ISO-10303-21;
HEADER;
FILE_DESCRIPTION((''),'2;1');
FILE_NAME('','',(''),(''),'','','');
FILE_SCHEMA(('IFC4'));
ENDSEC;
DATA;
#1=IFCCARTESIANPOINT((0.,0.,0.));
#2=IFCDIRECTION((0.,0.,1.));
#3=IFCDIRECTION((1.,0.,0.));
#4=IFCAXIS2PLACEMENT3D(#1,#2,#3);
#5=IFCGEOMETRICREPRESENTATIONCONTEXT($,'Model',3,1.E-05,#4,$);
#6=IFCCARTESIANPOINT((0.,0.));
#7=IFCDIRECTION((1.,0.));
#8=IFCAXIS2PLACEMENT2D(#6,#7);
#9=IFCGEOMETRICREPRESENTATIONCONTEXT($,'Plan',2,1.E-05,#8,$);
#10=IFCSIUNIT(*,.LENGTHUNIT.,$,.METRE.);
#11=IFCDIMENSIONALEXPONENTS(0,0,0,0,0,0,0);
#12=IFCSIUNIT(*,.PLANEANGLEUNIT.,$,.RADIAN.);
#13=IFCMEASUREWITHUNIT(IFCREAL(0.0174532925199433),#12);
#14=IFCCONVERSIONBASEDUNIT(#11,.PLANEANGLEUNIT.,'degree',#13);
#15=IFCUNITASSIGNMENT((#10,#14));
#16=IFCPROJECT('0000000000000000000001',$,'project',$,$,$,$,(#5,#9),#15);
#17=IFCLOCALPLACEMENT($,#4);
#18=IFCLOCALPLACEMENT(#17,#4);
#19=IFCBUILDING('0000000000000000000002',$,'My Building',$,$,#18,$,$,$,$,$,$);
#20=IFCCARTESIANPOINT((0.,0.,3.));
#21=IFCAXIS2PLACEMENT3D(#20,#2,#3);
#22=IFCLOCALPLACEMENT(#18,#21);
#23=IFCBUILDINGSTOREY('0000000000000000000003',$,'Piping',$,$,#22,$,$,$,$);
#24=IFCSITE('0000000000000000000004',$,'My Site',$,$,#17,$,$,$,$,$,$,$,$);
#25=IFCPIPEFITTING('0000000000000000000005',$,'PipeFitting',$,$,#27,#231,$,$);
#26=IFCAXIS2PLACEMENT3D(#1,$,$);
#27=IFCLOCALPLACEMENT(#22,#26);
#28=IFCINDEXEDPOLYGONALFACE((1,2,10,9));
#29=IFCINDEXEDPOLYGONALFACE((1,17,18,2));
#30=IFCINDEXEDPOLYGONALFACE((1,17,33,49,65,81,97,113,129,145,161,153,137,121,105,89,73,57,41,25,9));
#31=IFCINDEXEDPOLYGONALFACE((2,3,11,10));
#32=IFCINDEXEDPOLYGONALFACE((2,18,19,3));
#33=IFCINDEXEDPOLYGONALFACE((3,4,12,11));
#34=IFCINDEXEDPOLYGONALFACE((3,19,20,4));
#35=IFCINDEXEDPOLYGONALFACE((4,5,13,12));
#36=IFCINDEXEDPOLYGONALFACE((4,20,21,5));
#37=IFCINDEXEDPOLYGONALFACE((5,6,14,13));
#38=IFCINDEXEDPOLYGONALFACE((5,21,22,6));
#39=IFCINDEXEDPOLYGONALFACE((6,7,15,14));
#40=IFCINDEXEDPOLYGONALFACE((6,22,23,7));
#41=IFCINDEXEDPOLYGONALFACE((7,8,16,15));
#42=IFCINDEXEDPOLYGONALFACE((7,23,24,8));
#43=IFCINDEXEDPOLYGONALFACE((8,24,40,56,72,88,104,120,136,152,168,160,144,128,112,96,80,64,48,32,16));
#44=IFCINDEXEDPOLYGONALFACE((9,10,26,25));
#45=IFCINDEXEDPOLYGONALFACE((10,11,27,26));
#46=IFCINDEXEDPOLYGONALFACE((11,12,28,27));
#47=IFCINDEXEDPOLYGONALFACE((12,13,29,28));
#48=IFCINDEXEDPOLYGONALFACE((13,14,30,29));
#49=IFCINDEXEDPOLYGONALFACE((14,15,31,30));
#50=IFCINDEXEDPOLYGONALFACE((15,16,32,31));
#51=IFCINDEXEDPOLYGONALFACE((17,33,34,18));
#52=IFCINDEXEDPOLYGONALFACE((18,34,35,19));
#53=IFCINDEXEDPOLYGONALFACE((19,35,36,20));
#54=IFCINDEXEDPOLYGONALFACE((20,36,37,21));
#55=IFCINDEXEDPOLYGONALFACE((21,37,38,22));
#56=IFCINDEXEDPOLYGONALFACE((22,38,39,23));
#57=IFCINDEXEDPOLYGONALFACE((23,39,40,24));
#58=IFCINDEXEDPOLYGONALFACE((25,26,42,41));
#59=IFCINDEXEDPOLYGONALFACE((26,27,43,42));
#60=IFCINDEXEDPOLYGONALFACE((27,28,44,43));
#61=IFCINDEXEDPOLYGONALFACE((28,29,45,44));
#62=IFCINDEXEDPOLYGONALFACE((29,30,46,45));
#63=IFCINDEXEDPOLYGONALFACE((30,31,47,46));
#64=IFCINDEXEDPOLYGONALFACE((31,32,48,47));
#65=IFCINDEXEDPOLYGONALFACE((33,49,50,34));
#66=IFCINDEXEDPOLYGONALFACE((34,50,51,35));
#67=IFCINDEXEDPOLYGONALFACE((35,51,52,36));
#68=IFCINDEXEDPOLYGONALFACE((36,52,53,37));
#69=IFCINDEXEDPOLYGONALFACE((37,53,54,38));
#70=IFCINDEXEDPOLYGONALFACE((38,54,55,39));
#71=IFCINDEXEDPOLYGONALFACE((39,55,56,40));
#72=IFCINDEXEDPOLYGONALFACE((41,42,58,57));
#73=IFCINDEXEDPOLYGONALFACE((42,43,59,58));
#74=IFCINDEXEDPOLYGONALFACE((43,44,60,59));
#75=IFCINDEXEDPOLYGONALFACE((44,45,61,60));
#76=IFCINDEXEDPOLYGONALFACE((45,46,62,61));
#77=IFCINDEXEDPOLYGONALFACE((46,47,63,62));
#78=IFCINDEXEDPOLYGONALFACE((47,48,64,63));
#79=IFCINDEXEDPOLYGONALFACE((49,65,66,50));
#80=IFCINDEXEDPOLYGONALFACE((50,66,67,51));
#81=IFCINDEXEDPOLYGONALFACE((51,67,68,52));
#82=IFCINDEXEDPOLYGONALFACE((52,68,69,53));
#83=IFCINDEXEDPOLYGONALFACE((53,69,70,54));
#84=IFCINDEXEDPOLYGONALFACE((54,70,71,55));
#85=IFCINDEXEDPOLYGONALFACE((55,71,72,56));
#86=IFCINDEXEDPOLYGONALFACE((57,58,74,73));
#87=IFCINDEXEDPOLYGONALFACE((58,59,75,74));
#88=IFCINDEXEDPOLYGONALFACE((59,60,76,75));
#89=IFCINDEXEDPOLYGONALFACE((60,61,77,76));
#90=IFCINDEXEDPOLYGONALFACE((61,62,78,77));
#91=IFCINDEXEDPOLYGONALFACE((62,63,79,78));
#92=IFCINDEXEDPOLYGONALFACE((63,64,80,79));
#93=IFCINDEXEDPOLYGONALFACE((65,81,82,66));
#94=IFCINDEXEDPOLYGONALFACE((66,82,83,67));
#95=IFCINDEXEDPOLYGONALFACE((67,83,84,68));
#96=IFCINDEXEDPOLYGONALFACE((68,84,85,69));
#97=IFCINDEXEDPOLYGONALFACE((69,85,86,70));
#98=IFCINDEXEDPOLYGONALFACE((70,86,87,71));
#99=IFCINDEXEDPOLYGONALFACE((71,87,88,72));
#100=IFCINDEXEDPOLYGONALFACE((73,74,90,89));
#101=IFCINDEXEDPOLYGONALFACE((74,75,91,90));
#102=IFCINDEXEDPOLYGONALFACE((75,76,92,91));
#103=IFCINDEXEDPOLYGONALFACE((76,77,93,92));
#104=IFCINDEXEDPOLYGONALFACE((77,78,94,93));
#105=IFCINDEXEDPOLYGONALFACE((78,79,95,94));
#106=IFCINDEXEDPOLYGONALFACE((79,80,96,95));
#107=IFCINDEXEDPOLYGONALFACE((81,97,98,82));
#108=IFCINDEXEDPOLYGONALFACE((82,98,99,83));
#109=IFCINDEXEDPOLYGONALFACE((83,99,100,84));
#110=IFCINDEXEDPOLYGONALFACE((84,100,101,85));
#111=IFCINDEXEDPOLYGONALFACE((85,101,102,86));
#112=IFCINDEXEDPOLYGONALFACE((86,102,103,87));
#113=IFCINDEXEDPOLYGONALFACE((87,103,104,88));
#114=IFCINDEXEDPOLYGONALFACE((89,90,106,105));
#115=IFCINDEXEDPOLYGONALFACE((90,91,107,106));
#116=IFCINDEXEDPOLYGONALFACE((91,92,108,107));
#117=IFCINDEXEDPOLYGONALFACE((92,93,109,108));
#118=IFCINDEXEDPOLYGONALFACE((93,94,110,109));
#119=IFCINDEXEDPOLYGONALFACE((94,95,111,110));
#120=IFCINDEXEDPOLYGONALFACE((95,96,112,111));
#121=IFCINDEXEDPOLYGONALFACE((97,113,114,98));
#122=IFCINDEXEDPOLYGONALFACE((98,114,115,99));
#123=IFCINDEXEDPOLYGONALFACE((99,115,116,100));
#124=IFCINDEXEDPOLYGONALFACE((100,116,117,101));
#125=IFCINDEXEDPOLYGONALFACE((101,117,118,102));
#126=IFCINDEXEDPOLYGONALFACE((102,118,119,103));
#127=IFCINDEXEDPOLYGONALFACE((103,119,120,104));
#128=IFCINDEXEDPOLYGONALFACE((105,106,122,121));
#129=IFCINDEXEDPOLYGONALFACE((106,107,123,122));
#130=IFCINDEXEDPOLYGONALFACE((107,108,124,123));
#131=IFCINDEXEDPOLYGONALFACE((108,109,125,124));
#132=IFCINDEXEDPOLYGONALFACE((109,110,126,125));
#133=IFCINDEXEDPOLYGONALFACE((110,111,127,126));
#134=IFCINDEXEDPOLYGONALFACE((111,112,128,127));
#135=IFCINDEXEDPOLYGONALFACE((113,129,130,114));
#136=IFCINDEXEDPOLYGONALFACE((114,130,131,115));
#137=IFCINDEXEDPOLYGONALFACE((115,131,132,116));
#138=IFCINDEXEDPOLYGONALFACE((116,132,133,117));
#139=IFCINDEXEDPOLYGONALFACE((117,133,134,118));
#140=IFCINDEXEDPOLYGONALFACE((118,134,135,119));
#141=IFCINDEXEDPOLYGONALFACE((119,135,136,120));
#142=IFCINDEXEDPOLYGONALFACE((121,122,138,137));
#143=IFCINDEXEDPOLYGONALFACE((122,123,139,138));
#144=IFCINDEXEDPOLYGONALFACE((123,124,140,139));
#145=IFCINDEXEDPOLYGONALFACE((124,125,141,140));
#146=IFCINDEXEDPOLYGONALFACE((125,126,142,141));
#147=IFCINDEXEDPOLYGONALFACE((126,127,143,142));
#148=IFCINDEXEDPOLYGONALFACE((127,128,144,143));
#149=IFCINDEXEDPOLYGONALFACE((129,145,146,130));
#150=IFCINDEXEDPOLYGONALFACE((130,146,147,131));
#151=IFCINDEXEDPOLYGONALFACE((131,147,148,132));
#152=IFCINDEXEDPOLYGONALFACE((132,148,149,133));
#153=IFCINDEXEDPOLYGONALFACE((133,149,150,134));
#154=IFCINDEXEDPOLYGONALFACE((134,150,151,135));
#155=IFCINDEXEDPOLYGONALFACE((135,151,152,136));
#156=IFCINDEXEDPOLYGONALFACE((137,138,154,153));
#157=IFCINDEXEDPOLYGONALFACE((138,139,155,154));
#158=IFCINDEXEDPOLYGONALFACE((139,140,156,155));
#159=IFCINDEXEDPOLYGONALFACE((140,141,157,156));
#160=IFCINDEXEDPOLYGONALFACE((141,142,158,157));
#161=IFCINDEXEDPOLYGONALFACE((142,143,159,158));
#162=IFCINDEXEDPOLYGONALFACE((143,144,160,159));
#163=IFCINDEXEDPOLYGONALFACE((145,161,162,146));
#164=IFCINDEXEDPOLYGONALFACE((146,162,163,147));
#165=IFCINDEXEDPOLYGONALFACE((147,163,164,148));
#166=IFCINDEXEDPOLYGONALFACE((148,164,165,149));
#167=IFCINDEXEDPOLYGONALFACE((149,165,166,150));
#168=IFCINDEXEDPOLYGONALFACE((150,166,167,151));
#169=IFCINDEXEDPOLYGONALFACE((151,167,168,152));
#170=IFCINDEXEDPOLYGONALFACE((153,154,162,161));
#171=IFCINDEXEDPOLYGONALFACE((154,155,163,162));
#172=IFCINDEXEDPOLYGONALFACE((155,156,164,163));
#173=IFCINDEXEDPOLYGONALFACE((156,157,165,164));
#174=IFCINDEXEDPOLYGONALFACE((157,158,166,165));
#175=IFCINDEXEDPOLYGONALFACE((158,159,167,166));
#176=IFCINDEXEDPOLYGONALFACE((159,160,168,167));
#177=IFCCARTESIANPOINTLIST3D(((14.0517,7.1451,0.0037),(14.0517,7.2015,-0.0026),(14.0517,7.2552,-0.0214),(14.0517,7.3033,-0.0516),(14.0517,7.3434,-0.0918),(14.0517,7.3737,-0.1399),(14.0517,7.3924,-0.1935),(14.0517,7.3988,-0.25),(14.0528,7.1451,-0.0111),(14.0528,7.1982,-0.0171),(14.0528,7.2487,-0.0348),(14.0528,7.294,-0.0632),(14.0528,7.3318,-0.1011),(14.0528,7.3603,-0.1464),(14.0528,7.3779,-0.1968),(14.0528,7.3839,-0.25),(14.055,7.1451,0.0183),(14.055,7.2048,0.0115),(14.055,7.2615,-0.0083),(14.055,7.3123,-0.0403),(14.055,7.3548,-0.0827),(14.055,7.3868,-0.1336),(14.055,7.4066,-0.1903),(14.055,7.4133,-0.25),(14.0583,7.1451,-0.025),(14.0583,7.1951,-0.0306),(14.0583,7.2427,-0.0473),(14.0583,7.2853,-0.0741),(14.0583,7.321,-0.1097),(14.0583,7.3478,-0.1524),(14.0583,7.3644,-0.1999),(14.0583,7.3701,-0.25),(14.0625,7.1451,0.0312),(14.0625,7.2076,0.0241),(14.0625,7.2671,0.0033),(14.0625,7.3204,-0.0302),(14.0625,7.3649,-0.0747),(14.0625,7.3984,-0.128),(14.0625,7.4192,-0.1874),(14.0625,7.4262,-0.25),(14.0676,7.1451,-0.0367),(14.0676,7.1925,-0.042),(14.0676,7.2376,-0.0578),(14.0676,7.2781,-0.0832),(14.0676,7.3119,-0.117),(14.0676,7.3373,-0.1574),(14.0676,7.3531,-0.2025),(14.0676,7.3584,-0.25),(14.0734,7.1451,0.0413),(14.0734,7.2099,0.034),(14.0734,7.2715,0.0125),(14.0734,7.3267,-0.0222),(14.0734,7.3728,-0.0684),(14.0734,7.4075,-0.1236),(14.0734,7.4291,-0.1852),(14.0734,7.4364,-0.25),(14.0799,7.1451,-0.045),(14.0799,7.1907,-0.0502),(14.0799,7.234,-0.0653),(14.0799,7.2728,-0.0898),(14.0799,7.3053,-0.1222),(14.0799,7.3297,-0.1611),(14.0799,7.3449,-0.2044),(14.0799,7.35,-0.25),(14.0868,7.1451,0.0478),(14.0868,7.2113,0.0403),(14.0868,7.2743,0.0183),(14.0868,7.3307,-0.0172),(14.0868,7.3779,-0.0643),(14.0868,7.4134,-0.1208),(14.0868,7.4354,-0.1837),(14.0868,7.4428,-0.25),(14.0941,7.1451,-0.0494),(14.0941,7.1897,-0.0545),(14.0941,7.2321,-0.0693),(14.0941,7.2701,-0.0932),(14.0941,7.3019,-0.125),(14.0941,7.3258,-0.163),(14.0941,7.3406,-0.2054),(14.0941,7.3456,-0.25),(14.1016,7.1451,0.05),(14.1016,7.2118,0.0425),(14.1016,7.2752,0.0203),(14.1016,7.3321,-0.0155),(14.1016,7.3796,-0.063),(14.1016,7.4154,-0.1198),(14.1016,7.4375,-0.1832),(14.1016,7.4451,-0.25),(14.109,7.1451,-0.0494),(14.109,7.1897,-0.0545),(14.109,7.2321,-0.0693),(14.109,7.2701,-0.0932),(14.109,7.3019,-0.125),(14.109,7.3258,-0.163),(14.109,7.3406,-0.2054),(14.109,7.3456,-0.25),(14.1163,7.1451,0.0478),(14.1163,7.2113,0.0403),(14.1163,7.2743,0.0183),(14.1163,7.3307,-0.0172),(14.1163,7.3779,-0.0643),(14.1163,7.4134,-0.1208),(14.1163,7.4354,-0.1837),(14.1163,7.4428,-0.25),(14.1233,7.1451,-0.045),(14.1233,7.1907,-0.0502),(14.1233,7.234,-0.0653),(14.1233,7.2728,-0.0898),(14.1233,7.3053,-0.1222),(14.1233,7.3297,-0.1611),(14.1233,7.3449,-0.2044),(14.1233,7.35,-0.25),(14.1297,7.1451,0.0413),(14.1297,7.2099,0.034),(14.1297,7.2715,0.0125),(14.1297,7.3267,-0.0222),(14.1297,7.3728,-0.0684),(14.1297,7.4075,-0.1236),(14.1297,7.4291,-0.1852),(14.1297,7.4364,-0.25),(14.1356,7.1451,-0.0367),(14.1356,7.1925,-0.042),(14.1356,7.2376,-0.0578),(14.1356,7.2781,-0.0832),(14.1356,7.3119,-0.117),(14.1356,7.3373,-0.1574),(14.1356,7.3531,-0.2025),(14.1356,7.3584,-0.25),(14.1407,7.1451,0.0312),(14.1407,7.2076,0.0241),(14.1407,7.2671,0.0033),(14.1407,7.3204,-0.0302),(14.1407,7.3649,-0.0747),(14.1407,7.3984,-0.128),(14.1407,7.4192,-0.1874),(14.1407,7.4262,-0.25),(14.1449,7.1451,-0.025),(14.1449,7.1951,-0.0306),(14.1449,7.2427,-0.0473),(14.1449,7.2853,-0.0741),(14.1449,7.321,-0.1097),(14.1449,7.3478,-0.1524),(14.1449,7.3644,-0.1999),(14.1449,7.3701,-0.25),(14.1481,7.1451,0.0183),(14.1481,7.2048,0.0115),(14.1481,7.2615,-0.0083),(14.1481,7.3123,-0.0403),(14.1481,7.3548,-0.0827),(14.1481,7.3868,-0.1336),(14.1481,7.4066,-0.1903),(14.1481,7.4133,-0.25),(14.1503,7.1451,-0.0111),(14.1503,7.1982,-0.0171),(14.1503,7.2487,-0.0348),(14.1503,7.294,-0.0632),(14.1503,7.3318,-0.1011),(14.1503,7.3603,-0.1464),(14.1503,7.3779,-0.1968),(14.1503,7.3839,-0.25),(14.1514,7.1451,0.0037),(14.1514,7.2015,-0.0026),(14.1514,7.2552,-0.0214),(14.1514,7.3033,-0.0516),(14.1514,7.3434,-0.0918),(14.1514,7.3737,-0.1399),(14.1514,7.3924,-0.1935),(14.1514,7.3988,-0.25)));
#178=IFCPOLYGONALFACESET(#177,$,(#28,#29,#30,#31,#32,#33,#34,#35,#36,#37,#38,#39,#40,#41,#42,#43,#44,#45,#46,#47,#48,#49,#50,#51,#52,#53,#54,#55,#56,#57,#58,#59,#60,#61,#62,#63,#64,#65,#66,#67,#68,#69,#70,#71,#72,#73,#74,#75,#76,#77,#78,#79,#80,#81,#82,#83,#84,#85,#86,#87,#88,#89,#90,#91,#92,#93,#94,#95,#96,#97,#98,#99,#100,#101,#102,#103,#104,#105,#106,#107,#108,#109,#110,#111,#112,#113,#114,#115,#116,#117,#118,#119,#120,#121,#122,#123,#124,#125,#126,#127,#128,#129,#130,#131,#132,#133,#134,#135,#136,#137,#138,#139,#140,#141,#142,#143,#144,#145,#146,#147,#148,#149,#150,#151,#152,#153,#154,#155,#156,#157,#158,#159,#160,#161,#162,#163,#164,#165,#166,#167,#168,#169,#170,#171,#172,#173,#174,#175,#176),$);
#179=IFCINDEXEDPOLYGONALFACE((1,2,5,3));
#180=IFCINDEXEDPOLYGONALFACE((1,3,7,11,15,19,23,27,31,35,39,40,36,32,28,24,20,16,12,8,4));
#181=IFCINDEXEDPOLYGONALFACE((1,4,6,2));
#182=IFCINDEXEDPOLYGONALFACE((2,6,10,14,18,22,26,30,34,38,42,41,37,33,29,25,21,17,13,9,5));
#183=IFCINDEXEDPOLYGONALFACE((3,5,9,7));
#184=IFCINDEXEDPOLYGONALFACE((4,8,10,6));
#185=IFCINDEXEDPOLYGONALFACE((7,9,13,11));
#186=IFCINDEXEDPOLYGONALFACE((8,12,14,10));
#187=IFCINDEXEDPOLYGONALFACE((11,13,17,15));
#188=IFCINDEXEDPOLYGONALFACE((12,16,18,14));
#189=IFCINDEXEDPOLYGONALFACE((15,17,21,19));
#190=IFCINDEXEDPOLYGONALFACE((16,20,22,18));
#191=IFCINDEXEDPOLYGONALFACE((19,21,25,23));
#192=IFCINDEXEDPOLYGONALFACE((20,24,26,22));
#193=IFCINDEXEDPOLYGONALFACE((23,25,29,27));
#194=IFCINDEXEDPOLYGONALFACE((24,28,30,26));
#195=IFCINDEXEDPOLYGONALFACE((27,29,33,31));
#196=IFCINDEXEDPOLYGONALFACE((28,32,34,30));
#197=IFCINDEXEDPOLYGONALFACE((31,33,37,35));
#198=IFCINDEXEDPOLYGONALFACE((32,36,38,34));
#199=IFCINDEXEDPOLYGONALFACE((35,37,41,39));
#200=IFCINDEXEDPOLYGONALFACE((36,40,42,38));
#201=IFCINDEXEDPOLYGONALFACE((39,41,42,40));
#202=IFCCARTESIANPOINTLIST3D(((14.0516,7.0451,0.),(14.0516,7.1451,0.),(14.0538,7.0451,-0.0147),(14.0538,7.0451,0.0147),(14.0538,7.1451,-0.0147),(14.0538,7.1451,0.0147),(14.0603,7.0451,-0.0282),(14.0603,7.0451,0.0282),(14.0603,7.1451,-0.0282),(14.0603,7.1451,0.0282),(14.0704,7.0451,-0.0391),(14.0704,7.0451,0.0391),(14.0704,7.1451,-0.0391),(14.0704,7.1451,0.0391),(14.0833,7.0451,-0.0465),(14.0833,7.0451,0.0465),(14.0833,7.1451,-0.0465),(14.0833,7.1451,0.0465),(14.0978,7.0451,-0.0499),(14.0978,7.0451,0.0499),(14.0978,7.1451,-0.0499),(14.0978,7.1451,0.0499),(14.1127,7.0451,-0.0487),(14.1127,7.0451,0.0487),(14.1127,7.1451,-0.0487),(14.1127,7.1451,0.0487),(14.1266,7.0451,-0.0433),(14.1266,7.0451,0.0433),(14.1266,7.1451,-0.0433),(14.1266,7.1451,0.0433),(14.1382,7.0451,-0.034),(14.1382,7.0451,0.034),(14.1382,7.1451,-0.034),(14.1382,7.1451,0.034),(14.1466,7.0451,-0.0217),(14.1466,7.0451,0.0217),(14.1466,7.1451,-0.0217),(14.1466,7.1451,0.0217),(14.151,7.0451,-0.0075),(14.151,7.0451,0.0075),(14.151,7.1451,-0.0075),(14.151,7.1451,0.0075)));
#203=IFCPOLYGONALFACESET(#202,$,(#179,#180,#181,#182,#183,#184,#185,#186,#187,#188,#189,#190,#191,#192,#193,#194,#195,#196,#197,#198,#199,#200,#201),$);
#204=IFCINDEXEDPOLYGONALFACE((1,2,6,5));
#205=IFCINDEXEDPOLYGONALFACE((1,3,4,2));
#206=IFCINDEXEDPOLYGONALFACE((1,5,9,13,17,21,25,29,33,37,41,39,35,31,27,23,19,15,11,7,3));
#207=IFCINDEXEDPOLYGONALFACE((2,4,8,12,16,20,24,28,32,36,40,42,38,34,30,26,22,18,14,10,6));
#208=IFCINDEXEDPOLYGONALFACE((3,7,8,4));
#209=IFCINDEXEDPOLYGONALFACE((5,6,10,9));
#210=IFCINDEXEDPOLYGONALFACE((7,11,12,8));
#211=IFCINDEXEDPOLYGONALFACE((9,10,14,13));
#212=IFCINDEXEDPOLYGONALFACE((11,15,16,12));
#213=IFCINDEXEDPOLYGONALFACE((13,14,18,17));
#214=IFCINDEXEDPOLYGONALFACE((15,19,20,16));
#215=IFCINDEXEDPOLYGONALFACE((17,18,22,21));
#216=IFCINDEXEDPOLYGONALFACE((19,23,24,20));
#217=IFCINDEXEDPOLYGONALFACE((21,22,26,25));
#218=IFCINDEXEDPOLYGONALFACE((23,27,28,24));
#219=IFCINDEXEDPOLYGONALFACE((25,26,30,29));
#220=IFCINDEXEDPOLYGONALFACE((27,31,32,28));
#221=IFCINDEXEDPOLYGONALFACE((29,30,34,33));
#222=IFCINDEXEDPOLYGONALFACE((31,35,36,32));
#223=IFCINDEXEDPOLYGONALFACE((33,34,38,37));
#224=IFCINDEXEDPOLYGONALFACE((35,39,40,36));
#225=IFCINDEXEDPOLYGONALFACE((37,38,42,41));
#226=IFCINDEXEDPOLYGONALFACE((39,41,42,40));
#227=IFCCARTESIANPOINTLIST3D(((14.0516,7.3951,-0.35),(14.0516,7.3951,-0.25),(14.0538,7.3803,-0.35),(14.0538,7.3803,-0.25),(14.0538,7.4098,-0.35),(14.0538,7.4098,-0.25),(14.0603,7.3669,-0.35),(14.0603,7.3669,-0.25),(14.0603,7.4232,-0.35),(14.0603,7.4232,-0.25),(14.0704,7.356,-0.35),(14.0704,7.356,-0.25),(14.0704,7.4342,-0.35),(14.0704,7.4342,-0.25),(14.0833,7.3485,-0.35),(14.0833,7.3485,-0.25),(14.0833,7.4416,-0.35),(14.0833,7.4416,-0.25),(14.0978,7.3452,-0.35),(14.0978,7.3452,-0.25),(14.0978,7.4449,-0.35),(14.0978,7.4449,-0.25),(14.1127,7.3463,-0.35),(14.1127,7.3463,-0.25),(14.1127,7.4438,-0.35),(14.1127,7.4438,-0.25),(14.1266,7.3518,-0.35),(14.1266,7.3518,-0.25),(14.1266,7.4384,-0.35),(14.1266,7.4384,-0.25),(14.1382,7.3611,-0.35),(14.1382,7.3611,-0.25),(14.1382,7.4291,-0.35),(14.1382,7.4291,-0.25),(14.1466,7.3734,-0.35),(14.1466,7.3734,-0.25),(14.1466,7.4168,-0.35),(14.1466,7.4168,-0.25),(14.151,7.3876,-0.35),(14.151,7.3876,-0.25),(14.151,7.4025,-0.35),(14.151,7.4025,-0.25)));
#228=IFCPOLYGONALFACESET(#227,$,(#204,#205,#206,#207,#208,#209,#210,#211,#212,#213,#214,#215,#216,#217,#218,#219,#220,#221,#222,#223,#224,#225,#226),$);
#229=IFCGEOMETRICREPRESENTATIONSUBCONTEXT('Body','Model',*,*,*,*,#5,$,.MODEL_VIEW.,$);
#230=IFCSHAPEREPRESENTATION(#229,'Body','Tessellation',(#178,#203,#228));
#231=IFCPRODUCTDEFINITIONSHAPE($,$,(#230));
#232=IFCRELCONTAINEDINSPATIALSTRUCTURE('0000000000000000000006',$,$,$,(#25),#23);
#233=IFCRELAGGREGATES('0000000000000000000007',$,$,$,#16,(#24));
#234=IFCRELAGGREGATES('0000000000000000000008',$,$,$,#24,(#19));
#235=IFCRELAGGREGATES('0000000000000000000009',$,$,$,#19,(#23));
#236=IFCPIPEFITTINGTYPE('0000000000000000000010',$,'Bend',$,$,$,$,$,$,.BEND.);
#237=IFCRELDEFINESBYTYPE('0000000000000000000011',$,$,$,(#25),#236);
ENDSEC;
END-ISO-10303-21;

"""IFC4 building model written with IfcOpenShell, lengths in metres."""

from ifc_helpers import new_model, entity, si_unit, converted_unit, frame, origin_with_axes, origin_2d_with_axis, place, context, subcontext, project, spatial, circle, extrude, source, transform, mapped, type_object, type_shapes, element, save


model = new_model("IFC4")

# Units and contexts
model_context = context("Model", 3, precision=1e-05, world=origin_with_axes())
plan_context = context("Plan", 2, precision=1e-05, world=origin_2d_with_axis())
body_context = subcontext(model_context, "Body", "Model", "MODEL_VIEW")
ifc_project = project(units=[si_unit("LENGTHUNIT", "METRE"), converted_unit("PLANEANGLEUNIT", "degree", entity("IfcReal", 0.0174532925199433), si_unit("PLANEANGLEUNIT", "RADIAN"), dimensions=[0, 0, 0, 0, 0, 0, 0])], contexts=[model_context, plan_context])

# Site, building, storey
site_placement = place(None, origin_with_axes())
site = spatial("IfcSite", under=ifc_project, at=site_placement, Name="My Site")
building_placement = place(site_placement, origin_with_axes())
building = spatial("IfcBuilding", under=site, at=building_placement, Name="My Building")
storey_placement = place(building_placement, frame((0.0, 0.0, 3.0), z_axis=(0.0, 0.0, 1.0), x_axis=(1.0, 0.0, 0.0)))
storey = spatial("IfcBuildingStorey", under=building, at=storey_placement, Name="Piping")

# Shared definitions
pipe_fitting_type = type_object("IfcPipeFittingType", Name="Bend", PredefinedType="BEND")
shared_shape = source(origin_with_axes(), body_context, "Body", "SolidModel", [
    entity("IfcSweptDiskSolid", entity("IfcIndexedPolyCurve", entity("IfcCartesianPointList3D", [[0.0, 0.0, -0.1], [0.0, 0.0732, -0.2768], [0.0, 0.25, -0.35]]), [entity("IfcArcIndex", [1, 2, 3])]), 0.05),
    extrude(circle(Radius=0.05), origin_with_axes(), (0.0, 0.0, -1.0), 0.1),
    extrude(circle(Radius=0.05), frame((0.0, 0.25, -0.35), z_axis=(0.0, 1.0, 0.0), x_axis=(1.0, 0.0, 0.0)), (0.0, 0.0, 1.0), 0.1),
])
type_shapes(pipe_fitting_type, [shared_shape])

# Pipe fitting
for number, where, z_axis, x_axis, name in (
    (1, (14.1016, 7.0451, 0.0), (0.0, -1.0, 0.0), (-1.0, 0.0, 0.0), "PipeFitting"),
):
    element("IfcPipeFitting", number, at=place(storey_placement, frame(where, z_axis=z_axis, x_axis=x_axis)), inside=storey, type_object=pipe_fitting_type, Name=name, context=body_context, shape_type="MappedRepresentation", body=[
        mapped(shared_shape, transform((0.0, 0.0, 0.0), x_axis=(1.0, 0.0, 0.0), y_axis=(0.0, 1.0, 0.0), z_axis=(0.0, 0.0, 1.0), scale=1.0)),
    ])

save(model, "model.ifc")
